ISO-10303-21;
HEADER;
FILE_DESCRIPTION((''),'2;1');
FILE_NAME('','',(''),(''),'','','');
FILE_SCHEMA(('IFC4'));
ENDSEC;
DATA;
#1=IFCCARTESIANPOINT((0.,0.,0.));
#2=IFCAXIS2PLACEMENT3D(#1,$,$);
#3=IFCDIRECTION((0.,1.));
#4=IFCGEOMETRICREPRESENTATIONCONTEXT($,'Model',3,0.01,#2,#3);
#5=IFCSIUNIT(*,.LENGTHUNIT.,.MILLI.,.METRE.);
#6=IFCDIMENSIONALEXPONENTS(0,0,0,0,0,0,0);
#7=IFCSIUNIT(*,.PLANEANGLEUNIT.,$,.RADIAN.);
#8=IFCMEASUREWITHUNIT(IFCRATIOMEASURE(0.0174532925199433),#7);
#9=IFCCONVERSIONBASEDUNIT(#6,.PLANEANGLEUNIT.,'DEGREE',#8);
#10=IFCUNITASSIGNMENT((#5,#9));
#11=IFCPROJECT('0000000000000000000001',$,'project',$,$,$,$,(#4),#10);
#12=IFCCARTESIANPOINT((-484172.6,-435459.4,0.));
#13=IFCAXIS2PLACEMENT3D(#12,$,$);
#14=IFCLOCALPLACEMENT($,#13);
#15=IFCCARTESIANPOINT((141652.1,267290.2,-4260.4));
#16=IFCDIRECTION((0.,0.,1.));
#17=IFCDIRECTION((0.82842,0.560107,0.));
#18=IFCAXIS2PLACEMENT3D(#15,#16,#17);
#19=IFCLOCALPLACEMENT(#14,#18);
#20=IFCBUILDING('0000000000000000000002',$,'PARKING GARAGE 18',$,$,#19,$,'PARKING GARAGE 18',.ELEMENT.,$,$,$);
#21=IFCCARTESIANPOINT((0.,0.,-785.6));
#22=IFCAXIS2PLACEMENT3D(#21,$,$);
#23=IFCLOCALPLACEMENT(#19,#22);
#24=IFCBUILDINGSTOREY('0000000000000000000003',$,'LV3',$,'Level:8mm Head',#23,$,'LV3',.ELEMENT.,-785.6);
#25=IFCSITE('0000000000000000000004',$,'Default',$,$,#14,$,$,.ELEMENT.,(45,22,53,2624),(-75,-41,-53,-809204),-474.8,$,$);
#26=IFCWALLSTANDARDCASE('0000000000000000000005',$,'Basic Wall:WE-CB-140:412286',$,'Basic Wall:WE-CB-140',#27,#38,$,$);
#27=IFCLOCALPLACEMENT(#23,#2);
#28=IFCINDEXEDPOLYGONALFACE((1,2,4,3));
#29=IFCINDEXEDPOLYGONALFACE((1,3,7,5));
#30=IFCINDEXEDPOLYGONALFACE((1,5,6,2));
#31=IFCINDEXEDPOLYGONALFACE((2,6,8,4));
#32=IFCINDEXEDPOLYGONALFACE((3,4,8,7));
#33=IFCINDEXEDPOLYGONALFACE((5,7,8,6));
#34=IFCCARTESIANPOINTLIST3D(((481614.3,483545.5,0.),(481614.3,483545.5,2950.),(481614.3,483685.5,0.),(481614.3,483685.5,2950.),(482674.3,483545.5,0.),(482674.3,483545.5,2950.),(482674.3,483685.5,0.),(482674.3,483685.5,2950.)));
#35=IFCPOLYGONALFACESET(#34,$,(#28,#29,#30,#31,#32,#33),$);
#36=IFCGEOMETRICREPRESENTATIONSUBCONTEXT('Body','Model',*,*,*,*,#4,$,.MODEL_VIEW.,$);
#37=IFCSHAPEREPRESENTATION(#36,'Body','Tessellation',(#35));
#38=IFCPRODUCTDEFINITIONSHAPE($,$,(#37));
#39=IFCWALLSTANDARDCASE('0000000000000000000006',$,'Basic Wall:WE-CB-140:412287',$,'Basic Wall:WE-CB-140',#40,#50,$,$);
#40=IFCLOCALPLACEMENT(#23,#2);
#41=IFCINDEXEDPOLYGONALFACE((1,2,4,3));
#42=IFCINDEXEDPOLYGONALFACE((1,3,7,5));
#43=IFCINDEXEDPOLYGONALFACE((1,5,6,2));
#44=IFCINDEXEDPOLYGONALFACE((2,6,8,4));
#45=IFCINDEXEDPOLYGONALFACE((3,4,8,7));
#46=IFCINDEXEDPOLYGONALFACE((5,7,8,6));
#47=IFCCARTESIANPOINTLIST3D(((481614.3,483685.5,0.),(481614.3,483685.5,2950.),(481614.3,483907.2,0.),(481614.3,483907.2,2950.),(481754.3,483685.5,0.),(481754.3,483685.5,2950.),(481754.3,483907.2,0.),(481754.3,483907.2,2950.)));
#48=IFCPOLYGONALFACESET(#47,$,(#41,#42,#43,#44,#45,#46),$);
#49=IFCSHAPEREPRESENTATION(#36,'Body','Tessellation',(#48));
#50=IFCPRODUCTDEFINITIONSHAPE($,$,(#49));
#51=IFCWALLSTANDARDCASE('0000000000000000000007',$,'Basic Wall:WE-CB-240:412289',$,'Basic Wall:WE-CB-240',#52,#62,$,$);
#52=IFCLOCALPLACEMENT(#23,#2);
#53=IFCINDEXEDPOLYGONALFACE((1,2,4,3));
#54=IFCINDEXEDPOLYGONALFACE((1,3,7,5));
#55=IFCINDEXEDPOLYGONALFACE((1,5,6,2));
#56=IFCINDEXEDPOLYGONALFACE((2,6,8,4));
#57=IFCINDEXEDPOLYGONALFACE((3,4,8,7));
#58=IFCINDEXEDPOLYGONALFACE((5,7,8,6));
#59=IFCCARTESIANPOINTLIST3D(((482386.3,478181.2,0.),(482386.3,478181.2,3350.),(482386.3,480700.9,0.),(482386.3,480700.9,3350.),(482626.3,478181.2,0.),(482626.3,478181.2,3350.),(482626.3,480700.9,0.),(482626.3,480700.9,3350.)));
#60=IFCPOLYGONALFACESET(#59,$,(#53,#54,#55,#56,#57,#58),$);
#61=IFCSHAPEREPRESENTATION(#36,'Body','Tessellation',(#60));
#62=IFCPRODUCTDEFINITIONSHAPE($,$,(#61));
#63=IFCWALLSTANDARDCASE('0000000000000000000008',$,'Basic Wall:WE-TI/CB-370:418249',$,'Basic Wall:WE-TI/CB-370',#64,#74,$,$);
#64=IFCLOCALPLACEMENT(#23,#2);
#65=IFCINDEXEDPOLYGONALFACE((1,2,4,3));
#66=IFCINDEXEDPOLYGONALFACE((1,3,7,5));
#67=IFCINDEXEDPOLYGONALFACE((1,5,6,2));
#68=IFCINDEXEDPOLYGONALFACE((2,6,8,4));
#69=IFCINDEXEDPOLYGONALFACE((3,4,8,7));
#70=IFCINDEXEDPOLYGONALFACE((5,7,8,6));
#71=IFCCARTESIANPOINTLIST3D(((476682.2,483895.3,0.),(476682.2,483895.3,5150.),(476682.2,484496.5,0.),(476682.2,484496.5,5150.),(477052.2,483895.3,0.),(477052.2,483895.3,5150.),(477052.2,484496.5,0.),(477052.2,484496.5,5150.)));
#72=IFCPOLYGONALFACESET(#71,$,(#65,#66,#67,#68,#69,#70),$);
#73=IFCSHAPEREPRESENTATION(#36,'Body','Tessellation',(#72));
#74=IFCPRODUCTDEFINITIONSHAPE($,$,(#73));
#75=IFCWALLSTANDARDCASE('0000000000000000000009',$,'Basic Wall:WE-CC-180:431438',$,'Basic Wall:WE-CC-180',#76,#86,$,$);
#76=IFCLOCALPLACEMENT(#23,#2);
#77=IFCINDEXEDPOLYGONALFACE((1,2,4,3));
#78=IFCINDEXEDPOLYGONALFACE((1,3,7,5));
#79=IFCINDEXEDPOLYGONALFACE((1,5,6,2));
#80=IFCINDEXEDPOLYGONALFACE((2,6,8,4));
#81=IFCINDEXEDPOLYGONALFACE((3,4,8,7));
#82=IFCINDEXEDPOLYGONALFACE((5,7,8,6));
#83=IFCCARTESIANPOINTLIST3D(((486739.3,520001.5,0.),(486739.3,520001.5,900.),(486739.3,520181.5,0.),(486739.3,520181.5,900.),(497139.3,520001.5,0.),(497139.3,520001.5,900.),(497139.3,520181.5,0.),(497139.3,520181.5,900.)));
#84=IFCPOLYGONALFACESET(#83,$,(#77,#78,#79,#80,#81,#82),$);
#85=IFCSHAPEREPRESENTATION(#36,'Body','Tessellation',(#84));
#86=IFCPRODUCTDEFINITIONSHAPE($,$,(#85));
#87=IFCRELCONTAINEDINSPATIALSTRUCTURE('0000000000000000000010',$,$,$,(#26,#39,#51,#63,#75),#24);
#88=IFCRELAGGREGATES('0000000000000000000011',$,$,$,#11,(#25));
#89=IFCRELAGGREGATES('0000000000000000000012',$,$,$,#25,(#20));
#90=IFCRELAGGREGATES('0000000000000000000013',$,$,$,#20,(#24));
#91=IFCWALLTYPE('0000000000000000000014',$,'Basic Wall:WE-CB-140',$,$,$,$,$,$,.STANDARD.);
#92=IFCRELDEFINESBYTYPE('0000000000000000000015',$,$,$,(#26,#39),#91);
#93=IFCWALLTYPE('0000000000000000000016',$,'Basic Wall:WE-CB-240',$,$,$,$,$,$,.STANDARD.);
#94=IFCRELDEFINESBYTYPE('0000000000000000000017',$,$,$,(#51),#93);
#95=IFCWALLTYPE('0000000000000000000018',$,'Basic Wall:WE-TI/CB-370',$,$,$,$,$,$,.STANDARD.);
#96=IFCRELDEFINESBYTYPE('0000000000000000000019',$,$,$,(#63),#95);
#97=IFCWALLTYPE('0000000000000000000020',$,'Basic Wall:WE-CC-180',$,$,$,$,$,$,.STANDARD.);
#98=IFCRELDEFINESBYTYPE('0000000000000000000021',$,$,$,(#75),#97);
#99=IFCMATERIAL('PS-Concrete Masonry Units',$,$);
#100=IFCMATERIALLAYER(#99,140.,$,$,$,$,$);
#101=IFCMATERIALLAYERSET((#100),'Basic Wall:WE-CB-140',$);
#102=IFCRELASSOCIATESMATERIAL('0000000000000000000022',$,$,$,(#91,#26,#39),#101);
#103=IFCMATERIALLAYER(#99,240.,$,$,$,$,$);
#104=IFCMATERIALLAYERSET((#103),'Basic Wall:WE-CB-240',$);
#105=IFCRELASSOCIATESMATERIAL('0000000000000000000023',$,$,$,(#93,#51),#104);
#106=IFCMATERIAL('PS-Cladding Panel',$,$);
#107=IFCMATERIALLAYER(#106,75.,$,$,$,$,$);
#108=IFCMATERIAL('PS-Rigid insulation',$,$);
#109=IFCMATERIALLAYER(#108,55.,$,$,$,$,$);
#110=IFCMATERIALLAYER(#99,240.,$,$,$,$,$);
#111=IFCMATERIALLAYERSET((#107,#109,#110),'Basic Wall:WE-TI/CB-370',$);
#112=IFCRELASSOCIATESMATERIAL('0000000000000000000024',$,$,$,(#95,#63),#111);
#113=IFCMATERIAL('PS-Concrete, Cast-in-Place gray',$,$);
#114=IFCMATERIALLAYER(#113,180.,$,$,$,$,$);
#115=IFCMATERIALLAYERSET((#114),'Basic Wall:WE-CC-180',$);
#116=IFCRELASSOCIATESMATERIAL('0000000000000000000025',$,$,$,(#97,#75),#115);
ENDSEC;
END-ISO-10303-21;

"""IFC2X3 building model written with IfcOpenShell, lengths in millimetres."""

from ifc_helpers import new_model, entity, si_unit, converted_unit, direction, frame, frame_2d, origin, place, context, subcontext, project, spatial, rectangle, extrude, material, layer, layer_set, layer_usage, type_object, element, save


model = new_model("IFC2X3")

# Units and contexts
model_context = context("Model", 3, precision=0.01, world=origin(), true_north=direction((0.0, 1.0)))
body_context = subcontext(model_context, "Body", "Model", "MODEL_VIEW")
ifc_project = project(units=[si_unit("LENGTHUNIT", "METRE", prefix="MILLI"), converted_unit("PLANEANGLEUNIT", "DEGREE", entity("IfcRatioMeasure", 0.0174532925199433), si_unit("PLANEANGLEUNIT", "RADIAN"), dimensions=[0, 0, 0, 0, 0, 0, 0])], contexts=[model_context])

# Site, building, storey
site_placement = place(None, frame((-484172.6, -435459.4, 0.0)))
site = spatial("IfcSite", under=ifc_project, at=site_placement, Name="Default", CompositionType="ELEMENT", RefLatitude=(45, 22, 53, 2624), RefLongitude=(-75, -41, -53, -809204), RefElevation=-474.8)
building_placement = place(site_placement, frame((141652.1, 267290.2, -4260.4), z_axis=(0.0, 0.0, 1.0), x_axis=(0.82842, 0.560107, 0.0)))
building = spatial("IfcBuilding", under=site, at=building_placement, Name="PARKING GARAGE 18", LongName="PARKING GARAGE 18", CompositionType="ELEMENT")
storey_placement = place(building_placement, frame((0.0, 0.0, -785.6)))
storey = spatial("IfcBuildingStorey", under=building, at=storey_placement, Name="LV3", ObjectType="Level:8mm Head", LongName="LV3", CompositionType="ELEMENT", Elevation=-785.6)

# Walls
ifc_material_1 = material(Name="PS-Cladding Panel")
ifc_material_2 = material(Name="PS-Rigid insulation")
ifc_material_3 = material(Name="PS-Concrete Masonry Units")
ifc_material_4 = material(Name="PS-Concrete, Cast-in-Place gray")
ifc_layer_1 = layer(ifc_material_3, 140.0)
ifc_layer_set_1 = layer_set([ifc_layer_1], Name="Basic Wall:WE-CB-140")
wall_type_1 = type_object("IfcWallType", Name="Basic Wall:WE-CB-140", PredefinedType="STANDARD", material=ifc_layer_set_1)
ifc_layer_usage_1 = layer_usage(ifc_layer_set_1, "AXIS2", "NEGATIVE", 70.0)
wall_1_placement = place(storey_placement, frame((481614.3, 483615.5, 0.0)))
element("IfcWallStandardCase", 1, at=wall_1_placement, inside=storey, type_object=wall_type_1, material=ifc_layer_usage_1, Name="Basic Wall:WE-CB-140:412286", ObjectType="Basic Wall:WE-CB-140", context=body_context, shape_type="SweptSolid", body=[
    extrude(rectangle(XDim=1060.0, YDim=140.0, at=frame_2d((530.0, 0.0), x_axis=(-1.0, 0.0))), origin(), (0.0, 0.0, 1.0), 2950.0),
])
ifc_layer_usage_2 = layer_usage(ifc_layer_set_1, "AXIS2", "NEGATIVE", 70.0)
wall_2_placement = place(storey_placement, frame((481684.3, 483907.2, 0.0), z_axis=(0.0, 0.0, 1.0), x_axis=(0.0, -1.0, 0.0)))
element("IfcWallStandardCase", 2, at=wall_2_placement, inside=storey, type_object=wall_type_1, material=ifc_layer_usage_2, Name="Basic Wall:WE-CB-140:412287", ObjectType="Basic Wall:WE-CB-140", context=body_context, shape_type="SweptSolid", body=[
    extrude(rectangle(XDim=221.7, YDim=140.0, at=frame_2d((110.8, 0.0), x_axis=(-1.0, 0.0))), origin(), (0.0, 0.0, 1.0), 2950.0),
])
ifc_layer_2 = layer(ifc_material_3, 240.0)
ifc_layer_set_2 = layer_set([ifc_layer_2], Name="Basic Wall:WE-CB-240")
ifc_layer_usage_3 = layer_usage(ifc_layer_set_2, "AXIS2", "NEGATIVE", 120.0)
wall_type_2 = type_object("IfcWallType", Name="Basic Wall:WE-CB-240", PredefinedType="STANDARD", material=ifc_layer_set_2)
wall_3_placement = place(storey_placement, frame((482506.3, 480700.9, 0.0), z_axis=(0.0, 0.0, 1.0), x_axis=(0.0, -1.0, 0.0)))
element("IfcWallStandardCase", 3, at=wall_3_placement, inside=storey, type_object=wall_type_2, material=ifc_layer_usage_3, Name="Basic Wall:WE-CB-240:412289", ObjectType="Basic Wall:WE-CB-240", context=body_context, shape_type="SweptSolid", body=[
    extrude(rectangle(XDim=2519.7, YDim=240.0, at=frame_2d((1259.8, 0.0), x_axis=(-1.0, 0.0))), origin(), (0.0, 0.0, 1.0), 3350.0),
])
ifc_layer_3 = layer(ifc_material_1, 75.0)
ifc_layer_4 = layer(ifc_material_2, 55.0)
ifc_layer_5 = layer(ifc_material_3, 240.0)
ifc_layer_set_3 = layer_set([ifc_layer_3, ifc_layer_4, ifc_layer_5], Name="Basic Wall:WE-TI/CB-370")
ifc_layer_usage_4 = layer_usage(ifc_layer_set_3, "AXIS2", "NEGATIVE", 185.0)
wall_type_3 = type_object("IfcWallType", Name="Basic Wall:WE-TI/CB-370", PredefinedType="STANDARD", material=ifc_layer_set_3)
wall_4_placement = place(storey_placement, frame((476867.2, 483895.3, 0.0), z_axis=(0.0, 0.0, 1.0), x_axis=(0.0, 1.0, 0.0)))
element("IfcWallStandardCase", 4, at=wall_4_placement, inside=storey, type_object=wall_type_3, material=ifc_layer_usage_4, Name="Basic Wall:WE-TI/CB-370:418249", ObjectType="Basic Wall:WE-TI/CB-370", context=body_context, shape_type="SweptSolid", body=[
    extrude(rectangle(XDim=601.2, YDim=370.0, at=frame_2d((300.6, 0.0), x_axis=(-1.0, 0.0))), origin(), (0.0, 0.0, 1.0), 5150.0),
])
ifc_layer_6 = layer(ifc_material_4, 180.0)
ifc_layer_set_4 = layer_set([ifc_layer_6], Name="Basic Wall:WE-CC-180")
ifc_layer_usage_5 = layer_usage(ifc_layer_set_4, "AXIS2", "NEGATIVE", 90.0)
wall_type_4 = type_object("IfcWallType", Name="Basic Wall:WE-CC-180", PredefinedType="STANDARD", material=ifc_layer_set_4)
wall_5_placement = place(storey_placement, frame((486739.3, 520091.5, 0.0)))
element("IfcWallStandardCase", 5, at=wall_5_placement, inside=storey, type_object=wall_type_4, material=ifc_layer_usage_5, Name="Basic Wall:WE-CC-180:431438", ObjectType="Basic Wall:WE-CC-180", context=body_context, shape_type="SweptSolid", body=[
    extrude(rectangle(XDim=10400.0, YDim=180.0, at=frame_2d((5200.0, 0.0), x_axis=(-1.0, 0.0))), origin(), (0.0, 0.0, 1.0), 900.0),
])

save(model, "model.ifc")
